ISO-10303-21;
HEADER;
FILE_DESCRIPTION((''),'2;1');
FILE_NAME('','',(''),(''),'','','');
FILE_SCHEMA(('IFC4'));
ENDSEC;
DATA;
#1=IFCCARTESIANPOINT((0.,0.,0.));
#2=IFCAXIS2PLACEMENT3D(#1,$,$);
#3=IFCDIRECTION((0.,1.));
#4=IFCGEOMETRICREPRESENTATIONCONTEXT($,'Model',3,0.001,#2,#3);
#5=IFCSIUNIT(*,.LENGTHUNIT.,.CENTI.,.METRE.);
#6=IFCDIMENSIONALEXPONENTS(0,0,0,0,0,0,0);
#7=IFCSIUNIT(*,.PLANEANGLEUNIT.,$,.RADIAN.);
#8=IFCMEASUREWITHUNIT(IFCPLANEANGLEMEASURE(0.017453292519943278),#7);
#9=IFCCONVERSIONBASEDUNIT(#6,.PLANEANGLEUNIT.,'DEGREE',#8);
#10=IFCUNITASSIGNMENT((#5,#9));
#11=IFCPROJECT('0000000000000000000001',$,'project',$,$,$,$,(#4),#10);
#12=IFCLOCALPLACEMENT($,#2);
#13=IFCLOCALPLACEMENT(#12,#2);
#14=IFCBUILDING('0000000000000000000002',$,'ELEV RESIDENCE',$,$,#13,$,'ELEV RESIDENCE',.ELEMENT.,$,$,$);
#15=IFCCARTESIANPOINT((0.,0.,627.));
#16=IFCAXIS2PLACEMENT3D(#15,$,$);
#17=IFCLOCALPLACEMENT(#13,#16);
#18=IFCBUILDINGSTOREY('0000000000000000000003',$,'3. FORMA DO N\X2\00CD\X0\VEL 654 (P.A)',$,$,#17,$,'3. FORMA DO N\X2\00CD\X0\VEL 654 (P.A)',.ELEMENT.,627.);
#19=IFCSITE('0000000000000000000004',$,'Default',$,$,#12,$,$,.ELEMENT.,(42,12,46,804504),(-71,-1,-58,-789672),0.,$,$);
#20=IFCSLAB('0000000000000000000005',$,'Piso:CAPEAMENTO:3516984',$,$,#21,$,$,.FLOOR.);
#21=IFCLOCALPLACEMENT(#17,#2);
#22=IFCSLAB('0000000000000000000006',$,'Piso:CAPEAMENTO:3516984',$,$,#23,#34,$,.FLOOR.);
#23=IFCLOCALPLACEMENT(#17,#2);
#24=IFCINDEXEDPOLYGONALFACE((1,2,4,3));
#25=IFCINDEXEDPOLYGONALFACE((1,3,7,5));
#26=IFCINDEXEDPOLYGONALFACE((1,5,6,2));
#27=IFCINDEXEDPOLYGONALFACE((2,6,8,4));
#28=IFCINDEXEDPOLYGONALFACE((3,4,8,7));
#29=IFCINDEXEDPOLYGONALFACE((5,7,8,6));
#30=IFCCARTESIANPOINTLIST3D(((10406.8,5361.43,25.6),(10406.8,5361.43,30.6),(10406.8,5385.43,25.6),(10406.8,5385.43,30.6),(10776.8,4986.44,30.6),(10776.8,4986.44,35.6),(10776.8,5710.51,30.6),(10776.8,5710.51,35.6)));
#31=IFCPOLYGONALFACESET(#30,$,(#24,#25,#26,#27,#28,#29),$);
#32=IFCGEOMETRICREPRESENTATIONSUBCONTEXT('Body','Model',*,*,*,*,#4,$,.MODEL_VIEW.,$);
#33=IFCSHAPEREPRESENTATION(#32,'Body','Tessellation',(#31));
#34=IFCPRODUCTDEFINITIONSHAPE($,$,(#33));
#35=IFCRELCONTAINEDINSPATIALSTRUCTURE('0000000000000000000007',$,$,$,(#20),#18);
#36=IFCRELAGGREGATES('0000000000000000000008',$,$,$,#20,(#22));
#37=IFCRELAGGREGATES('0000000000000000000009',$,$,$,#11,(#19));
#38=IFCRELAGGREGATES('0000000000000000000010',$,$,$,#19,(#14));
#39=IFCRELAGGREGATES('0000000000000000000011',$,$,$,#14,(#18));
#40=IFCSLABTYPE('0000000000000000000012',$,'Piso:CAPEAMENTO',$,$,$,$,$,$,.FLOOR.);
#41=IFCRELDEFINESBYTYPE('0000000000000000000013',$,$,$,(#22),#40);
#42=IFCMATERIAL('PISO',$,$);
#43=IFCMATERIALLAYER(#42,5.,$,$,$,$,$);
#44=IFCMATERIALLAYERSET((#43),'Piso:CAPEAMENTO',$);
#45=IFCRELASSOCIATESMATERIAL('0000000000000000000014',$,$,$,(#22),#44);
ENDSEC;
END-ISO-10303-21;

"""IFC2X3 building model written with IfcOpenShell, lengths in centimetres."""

from ifc_helpers import new_model, entity, si_unit, converted_unit, direction, frame, origin, place, context, subcontext, project, spatial, polyline, outline, extrude, material, layer, layer_set, type_object, element, aggregate, save


model = new_model("IFC2X3")

# Units and contexts
model_context = context("Model", 3, precision=0.001, world=origin(), true_north=direction((0.0, 1.0)))
body_context = subcontext(model_context, "Body", "Model", "MODEL_VIEW")
ifc_project = project(units=[si_unit("LENGTHUNIT", "METRE", prefix="CENTI"), converted_unit("PLANEANGLEUNIT", "DEGREE", entity("IfcPlaneAngleMeasure", 0.017453292519943278), si_unit("PLANEANGLEUNIT", "RADIAN"), dimensions=[0, 0, 0, 0, 0, 0, 0])], contexts=[model_context])

# Site, building, storey
site_placement = place(None, origin())
site = spatial("IfcSite", under=ifc_project, at=site_placement, Name="Default", CompositionType="ELEMENT", RefLatitude=(42, 12, 46, 804504), RefLongitude=(-71, -1, -58, -789672), RefElevation=0.0)
building_placement = place(site_placement, origin())
building = spatial("IfcBuilding", under=site, at=building_placement, Name="ELEV RESIDENCE", LongName="ELEV RESIDENCE", CompositionType="ELEMENT")
storey_placement = place(building_placement, frame((0.0, 0.0, 627.0)))
storey = spatial("IfcBuildingStorey", under=building, at=storey_placement, Name="3. FORMA DO NÍVEL 654 (P.A)", LongName="3. FORMA DO NÍVEL 654 (P.A)", CompositionType="ELEMENT", Elevation=627.0)

# Slabs
slab_1_placement = place(storey_placement, frame((9186.8, 4986.44, 25.6)))
slab_1 = element("IfcSlab", 1, at=slab_1_placement, inside=storey, Name="Piso:CAPEAMENTO:3516984", PredefinedType="FLOOR")
ifc_material = material(Name="PISO")
ifc_layer = layer(ifc_material, 5.0)
ifc_layer_set = layer_set([ifc_layer], Name="Piso:CAPEAMENTO")
slab_type = type_object("IfcSlabType", Name="Piso:CAPEAMENTO", PredefinedType="FLOOR")
slab_2_placement = place(slab_1_placement, origin())
slab_2 = element("IfcSlab", 2, at=slab_2_placement, type_object=slab_type, material=ifc_layer_set, Name="Piso:CAPEAMENTO:3516984", PredefinedType="FLOOR", context=body_context, shape_type="SweptSolid", body=[
    extrude(outline(polyline([(185.01, -362.04), (185.01, 362.04), (-185.01, 36.96), (-185.01, 12.96), (185.01, -362.04)])), frame((1405.0, 362.04, 7.5), z_axis=(-0.013512, 0.0, 0.999909), x_axis=(0.999909, 0.0, 0.013512)), (-0.013512, 0.0, -0.999909), 5.0),
])
aggregate(slab_1, [slab_2])

save(model, "model.ifc")
